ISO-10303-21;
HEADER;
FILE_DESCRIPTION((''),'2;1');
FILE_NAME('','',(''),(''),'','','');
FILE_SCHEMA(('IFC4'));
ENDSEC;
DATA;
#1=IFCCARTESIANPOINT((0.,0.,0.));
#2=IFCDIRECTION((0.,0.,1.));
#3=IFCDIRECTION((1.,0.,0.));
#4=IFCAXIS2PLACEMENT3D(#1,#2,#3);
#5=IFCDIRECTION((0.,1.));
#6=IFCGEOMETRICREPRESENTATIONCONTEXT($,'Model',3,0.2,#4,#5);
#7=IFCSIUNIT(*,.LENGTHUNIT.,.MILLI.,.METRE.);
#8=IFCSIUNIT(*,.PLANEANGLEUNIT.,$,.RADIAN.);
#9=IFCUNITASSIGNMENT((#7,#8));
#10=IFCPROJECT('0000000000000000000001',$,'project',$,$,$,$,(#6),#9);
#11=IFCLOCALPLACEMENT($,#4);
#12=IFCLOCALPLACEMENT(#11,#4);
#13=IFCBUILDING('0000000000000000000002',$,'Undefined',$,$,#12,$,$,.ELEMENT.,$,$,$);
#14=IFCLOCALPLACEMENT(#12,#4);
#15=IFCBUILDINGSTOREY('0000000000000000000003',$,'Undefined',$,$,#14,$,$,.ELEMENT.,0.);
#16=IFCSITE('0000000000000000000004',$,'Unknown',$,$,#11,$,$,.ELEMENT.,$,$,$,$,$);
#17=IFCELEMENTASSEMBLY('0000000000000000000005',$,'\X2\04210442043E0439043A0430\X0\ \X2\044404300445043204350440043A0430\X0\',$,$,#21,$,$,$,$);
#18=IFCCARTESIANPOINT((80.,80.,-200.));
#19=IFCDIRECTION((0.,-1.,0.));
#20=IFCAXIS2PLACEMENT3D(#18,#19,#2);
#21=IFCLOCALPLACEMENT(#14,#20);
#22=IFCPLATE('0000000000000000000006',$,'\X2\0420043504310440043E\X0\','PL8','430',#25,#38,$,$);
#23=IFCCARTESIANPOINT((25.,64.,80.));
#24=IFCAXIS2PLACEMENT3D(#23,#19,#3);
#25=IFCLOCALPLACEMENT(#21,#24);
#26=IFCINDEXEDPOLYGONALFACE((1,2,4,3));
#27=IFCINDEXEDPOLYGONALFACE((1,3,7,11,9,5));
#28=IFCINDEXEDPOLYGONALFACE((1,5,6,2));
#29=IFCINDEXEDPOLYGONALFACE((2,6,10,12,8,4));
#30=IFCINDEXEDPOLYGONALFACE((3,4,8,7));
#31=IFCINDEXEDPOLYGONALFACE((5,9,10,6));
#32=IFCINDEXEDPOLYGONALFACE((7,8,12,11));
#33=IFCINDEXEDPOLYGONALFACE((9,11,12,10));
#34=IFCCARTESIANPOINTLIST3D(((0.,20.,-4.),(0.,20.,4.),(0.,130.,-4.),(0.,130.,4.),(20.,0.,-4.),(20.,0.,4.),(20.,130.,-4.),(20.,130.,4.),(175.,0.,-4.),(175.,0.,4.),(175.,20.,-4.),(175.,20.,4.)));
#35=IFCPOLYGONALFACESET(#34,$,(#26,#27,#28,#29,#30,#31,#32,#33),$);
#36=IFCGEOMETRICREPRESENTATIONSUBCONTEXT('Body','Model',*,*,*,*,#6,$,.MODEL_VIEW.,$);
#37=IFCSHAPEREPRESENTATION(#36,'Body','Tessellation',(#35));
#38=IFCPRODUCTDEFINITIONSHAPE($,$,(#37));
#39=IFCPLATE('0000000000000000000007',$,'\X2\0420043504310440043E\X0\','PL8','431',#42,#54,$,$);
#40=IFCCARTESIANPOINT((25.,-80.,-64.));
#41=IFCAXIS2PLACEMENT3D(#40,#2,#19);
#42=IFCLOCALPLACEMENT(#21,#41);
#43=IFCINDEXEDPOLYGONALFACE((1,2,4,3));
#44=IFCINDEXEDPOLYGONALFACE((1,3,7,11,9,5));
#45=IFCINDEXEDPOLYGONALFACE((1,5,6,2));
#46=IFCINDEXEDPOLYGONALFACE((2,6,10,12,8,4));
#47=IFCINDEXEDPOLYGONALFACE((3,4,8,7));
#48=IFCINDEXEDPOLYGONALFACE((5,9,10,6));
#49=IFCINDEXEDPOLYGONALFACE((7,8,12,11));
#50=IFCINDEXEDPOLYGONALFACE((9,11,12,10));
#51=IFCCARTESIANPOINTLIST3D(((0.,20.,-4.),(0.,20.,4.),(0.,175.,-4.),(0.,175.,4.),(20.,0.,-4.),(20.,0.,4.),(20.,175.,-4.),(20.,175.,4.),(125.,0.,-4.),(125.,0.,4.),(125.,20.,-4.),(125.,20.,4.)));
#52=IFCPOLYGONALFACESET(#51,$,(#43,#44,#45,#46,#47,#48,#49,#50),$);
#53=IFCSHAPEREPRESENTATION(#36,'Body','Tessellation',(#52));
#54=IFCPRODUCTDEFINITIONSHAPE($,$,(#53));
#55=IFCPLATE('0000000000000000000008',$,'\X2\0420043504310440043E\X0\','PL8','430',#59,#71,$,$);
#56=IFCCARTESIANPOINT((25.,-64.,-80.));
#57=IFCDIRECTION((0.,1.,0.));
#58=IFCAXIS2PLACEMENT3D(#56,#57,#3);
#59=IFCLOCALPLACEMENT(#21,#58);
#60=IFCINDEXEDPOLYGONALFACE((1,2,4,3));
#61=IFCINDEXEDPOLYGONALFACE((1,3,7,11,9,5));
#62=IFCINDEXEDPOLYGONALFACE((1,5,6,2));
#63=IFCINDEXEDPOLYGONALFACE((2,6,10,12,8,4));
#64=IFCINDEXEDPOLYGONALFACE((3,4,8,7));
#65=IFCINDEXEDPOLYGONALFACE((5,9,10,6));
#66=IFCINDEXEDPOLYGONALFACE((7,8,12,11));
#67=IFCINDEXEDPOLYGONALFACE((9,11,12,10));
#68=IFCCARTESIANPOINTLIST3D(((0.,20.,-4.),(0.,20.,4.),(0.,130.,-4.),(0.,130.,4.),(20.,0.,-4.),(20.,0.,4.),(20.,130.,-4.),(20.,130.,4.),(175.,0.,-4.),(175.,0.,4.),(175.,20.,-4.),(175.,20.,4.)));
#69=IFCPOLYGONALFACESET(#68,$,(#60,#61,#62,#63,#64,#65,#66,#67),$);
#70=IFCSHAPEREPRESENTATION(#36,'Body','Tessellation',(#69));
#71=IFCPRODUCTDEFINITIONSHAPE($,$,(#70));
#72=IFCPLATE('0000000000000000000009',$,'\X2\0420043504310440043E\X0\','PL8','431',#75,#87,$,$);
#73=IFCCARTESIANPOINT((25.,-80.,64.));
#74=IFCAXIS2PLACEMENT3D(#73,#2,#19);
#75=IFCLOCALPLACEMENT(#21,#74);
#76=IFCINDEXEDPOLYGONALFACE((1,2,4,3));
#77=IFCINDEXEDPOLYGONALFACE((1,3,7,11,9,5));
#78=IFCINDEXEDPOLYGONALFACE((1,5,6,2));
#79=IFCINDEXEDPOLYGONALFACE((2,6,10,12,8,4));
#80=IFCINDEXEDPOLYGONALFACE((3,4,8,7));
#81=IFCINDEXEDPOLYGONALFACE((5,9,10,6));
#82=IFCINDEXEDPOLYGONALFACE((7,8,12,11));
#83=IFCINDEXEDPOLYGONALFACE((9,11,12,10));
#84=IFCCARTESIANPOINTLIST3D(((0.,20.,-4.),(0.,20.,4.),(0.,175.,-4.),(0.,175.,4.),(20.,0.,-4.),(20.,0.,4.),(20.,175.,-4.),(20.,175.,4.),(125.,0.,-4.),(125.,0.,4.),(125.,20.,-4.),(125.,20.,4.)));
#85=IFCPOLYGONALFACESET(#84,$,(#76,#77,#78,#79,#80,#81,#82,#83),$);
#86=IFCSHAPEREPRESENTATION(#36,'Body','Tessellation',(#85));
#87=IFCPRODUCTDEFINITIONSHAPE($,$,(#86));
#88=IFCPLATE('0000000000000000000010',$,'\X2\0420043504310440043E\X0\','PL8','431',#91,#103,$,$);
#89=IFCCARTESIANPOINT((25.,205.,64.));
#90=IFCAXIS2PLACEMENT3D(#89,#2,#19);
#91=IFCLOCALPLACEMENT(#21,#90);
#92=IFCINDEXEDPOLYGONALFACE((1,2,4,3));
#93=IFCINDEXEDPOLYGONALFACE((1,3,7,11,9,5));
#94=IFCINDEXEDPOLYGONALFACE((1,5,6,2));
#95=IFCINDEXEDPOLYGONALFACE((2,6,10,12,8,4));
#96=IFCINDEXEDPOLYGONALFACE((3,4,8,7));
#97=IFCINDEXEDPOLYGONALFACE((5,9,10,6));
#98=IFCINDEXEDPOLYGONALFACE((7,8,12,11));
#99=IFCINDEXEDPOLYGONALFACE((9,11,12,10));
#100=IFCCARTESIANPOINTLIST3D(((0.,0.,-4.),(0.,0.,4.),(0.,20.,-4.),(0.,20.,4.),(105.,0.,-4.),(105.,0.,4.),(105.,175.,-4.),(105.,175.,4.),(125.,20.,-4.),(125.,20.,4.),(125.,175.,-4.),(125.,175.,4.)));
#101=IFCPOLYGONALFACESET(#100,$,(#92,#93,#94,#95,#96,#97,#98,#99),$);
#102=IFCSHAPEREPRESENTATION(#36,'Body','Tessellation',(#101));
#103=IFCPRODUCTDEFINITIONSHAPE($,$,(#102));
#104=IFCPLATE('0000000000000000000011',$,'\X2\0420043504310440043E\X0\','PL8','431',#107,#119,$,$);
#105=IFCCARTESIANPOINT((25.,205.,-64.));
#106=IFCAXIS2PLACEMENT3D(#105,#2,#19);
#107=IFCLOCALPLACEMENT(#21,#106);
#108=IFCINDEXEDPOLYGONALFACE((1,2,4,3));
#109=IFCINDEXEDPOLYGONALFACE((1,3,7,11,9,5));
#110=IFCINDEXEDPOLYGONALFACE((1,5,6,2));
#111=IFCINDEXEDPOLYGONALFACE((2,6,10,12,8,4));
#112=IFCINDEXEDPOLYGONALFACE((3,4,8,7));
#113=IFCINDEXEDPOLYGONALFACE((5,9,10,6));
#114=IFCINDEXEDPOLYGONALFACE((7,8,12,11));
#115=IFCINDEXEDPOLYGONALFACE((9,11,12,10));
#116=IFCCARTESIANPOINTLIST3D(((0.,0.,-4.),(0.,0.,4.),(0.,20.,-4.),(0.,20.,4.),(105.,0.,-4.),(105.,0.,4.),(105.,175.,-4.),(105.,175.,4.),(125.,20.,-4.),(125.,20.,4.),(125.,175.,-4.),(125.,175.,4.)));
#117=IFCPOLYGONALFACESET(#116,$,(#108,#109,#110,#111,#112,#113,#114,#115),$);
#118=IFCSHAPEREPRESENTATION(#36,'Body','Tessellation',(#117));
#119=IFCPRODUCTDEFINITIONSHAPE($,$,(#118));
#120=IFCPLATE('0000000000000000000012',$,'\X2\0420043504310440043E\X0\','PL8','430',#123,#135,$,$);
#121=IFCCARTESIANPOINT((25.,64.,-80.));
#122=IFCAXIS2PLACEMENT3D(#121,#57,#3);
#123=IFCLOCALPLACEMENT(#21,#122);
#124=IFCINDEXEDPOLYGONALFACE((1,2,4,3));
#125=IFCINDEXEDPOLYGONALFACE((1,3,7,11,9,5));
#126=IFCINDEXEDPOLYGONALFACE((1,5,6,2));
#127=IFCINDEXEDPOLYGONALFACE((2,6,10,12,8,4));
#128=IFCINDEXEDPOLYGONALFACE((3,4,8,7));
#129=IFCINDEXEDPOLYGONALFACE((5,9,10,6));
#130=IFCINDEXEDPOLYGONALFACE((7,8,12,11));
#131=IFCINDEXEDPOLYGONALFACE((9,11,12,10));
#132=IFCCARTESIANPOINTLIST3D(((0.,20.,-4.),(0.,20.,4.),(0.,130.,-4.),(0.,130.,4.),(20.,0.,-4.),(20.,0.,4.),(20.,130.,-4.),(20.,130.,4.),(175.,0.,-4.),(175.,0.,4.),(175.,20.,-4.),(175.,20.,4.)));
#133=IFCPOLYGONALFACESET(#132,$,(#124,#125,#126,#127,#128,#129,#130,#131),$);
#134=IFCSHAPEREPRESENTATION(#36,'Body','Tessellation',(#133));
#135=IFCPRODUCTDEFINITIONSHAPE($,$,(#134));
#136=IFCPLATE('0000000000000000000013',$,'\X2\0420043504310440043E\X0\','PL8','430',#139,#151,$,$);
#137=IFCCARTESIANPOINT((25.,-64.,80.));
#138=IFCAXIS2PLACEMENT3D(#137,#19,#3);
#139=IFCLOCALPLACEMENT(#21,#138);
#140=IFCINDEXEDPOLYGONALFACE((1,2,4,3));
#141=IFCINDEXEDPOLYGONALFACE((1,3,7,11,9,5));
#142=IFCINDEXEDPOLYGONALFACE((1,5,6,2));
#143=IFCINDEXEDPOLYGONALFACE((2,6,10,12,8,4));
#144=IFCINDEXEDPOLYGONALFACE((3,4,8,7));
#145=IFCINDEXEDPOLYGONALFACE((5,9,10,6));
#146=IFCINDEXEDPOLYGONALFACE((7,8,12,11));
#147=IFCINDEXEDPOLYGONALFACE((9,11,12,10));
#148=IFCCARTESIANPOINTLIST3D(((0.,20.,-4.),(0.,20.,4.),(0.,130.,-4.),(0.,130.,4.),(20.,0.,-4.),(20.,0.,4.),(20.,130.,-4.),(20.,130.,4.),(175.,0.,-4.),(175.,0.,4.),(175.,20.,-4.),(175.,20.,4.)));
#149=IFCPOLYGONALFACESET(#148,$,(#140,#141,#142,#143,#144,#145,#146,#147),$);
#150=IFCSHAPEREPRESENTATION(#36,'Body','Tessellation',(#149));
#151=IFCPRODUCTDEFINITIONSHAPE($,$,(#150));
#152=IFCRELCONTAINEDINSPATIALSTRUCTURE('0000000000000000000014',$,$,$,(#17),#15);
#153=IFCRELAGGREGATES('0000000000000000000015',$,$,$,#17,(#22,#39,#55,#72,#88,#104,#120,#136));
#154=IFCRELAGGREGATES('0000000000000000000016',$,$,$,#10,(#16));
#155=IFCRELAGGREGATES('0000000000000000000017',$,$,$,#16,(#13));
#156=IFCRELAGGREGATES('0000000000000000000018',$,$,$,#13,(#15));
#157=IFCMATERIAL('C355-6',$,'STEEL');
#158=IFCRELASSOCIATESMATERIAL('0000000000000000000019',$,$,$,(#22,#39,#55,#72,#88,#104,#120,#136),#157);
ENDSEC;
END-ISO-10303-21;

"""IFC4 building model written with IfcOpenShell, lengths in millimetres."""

from ifc_helpers import new_model, si_unit, direction, frame, origin_with_axes, place, context, subcontext, project, spatial, line, indexed_curve, outline, extrude, material, element, aggregate, save


model = new_model("IFC4")

# Units and contexts
model_context = context("Model", 3, precision=0.2, world=origin_with_axes(), true_north=direction((0.0, 1.0)))
body_context = subcontext(model_context, "Body", "Model", "MODEL_VIEW")
ifc_project = project(units=[si_unit("LENGTHUNIT", "METRE", prefix="MILLI"), si_unit("PLANEANGLEUNIT", "RADIAN")], contexts=[model_context])

# Site, building, storey
site_placement = place(None, origin_with_axes())
site = spatial("IfcSite", under=ifc_project, at=site_placement, Name="Unknown", CompositionType="ELEMENT")
building_placement = place(site_placement, origin_with_axes())
building = spatial("IfcBuilding", under=site, at=building_placement, Name="Undefined", CompositionType="ELEMENT")
storey_placement = place(building_placement, origin_with_axes())
storey = spatial("IfcBuildingStorey", under=building, at=storey_placement, Name="Undefined", CompositionType="ELEMENT", Elevation=0.0)

# Element assembly
assembly_1_placement = place(storey_placement, frame((80.0, 80.0, -200.0), z_axis=(0.0, -1.0, 0.0), x_axis=(0.0, 0.0, 1.0)))
assembly_1 = element("IfcElementAssembly", 1, at=assembly_1_placement, inside=storey, Name="Стойка фахверка")
ifc_material_1 = material(Name="C355-6", Category="STEEL")

# Plates
plate_1_placement = place(assembly_1_placement, frame((25.0, 64.0, 80.0), z_axis=(0.0, -1.0, 0.0), x_axis=(1.0, 0.0, 0.0)))
plate_1 = element("IfcPlate", 2, at=plate_1_placement, material=ifc_material_1, Name="Ребро", Description="PL8", ObjectType="430", context=body_context, shape_type="SolidModel", body=[
    extrude(outline(indexed_curve([(0.0, 20.0), (20.0, 0.0), (175.0, 0.0), (175.0, 20.0), (20.0, 130.0), (0.0, 130.0)], segments=[line(1, 2, 3, 4, 5, 6, 1)])), frame((0.0, 0.0, 4.0), z_axis=(0.0, 0.0, 1.0), x_axis=(1.0, 0.0, 0.0)), (0.0, 0.0, -1.0), 8.0),
])
plate_2_placement = place(assembly_1_placement, frame((25.0, -80.0, -64.0), z_axis=(0.0, 0.0, 1.0), x_axis=(0.0, -1.0, 0.0)))
plate_2 = element("IfcPlate", 3, at=plate_2_placement, material=ifc_material_1, Name="Ребро", Description="PL8", ObjectType="431", context=body_context, shape_type="SolidModel", body=[
    extrude(outline(indexed_curve([(0.0, 20.0), (20.0, 0.0), (125.0, 0.0), (125.0, 20.0), (20.0, 175.0), (0.0, 175.0)], segments=[line(1, 2, 3, 4, 5, 6, 1)])), frame((0.0, 0.0, 4.0), z_axis=(0.0, 0.0, 1.0), x_axis=(1.0, 0.0, 0.0)), (0.0, 0.0, -1.0), 8.0),
])
plate_3_placement = place(assembly_1_placement, frame((25.0, -64.0, -80.0), z_axis=(0.0, 1.0, 0.0), x_axis=(1.0, 0.0, 0.0)))
plate_3 = element("IfcPlate", 4, at=plate_3_placement, material=ifc_material_1, Name="Ребро", Description="PL8", ObjectType="430", context=body_context, shape_type="SolidModel", body=[
    extrude(outline(indexed_curve([(0.0, 20.0), (20.0, 0.0), (175.0, 0.0), (175.0, 20.0), (20.0, 130.0), (0.0, 130.0)], segments=[line(1, 2, 3, 4, 5, 6, 1)])), frame((0.0, 0.0, 4.0), z_axis=(0.0, 0.0, 1.0), x_axis=(1.0, 0.0, 0.0)), (0.0, 0.0, -1.0), 8.0),
])
plate_4_placement = place(assembly_1_placement, frame((25.0, -80.0, 64.0), z_axis=(0.0, 0.0, 1.0), x_axis=(0.0, -1.0, 0.0)))
plate_4 = element("IfcPlate", 5, at=plate_4_placement, material=ifc_material_1, Name="Ребро", Description="PL8", ObjectType="431", context=body_context, shape_type="SolidModel", body=[
    extrude(outline(indexed_curve([(0.0, 20.0), (20.0, 0.0), (125.0, 0.0), (125.0, 20.0), (20.0, 175.0), (0.0, 175.0)], segments=[line(1, 2, 3, 4, 5, 6, 1)])), frame((0.0, 0.0, 4.0), z_axis=(0.0, 0.0, 1.0), x_axis=(1.0, 0.0, 0.0)), (0.0, 0.0, -1.0), 8.0),
])
plate_5_placement = place(assembly_1_placement, frame((25.0, 205.0, 64.0), z_axis=(0.0, 0.0, 1.0), x_axis=(0.0, -1.0, 0.0)))
plate_5 = element("IfcPlate", 6, at=plate_5_placement, material=ifc_material_1, Name="Ребро", Description="PL8", ObjectType="431", context=body_context, shape_type="SolidModel", body=[
    extrude(outline(indexed_curve([(0.0, 0.0), (105.0, 0.0), (125.0, 20.0), (125.0, 175.0), (105.0, 175.0), (0.0, 20.0)], segments=[line(1, 2, 3, 4, 5, 6, 1)])), frame((0.0, 0.0, 4.0), z_axis=(0.0, 0.0, 1.0), x_axis=(1.0, 0.0, 0.0)), (0.0, 0.0, -1.0), 8.0),
])
plate_6_placement = place(assembly_1_placement, frame((25.0, 205.0, -64.0), z_axis=(0.0, 0.0, 1.0), x_axis=(0.0, -1.0, 0.0)))
plate_6 = element("IfcPlate", 7, at=plate_6_placement, material=ifc_material_1, Name="Ребро", Description="PL8", ObjectType="431", context=body_context, shape_type="SolidModel", body=[
    extrude(outline(indexed_curve([(0.0, 0.0), (105.0, 0.0), (125.0, 20.0), (125.0, 175.0), (105.0, 175.0), (0.0, 20.0)], segments=[line(1, 2, 3, 4, 5, 6, 1)])), frame((0.0, 0.0, 4.0), z_axis=(0.0, 0.0, 1.0), x_axis=(1.0, 0.0, 0.0)), (0.0, 0.0, -1.0), 8.0),
])
plate_7_placement = place(assembly_1_placement, frame((25.0, 64.0, -80.0), z_axis=(0.0, 1.0, 0.0), x_axis=(1.0, 0.0, 0.0)))
plate_7 = element("IfcPlate", 8, at=plate_7_placement, material=ifc_material_1, Name="Ребро", Description="PL8", ObjectType="430", context=body_context, shape_type="SolidModel", body=[
    extrude(outline(indexed_curve([(0.0, 20.0), (20.0, 0.0), (175.0, 0.0), (175.0, 20.0), (20.0, 130.0), (0.0, 130.0)], segments=[line(1, 2, 3, 4, 5, 6, 1)])), frame((0.0, 0.0, 4.0), z_axis=(0.0, 0.0, 1.0), x_axis=(1.0, 0.0, 0.0)), (0.0, 0.0, -1.0), 8.0),
])
plate_8_placement = place(assembly_1_placement, frame((25.0, -64.0, 80.0), z_axis=(0.0, -1.0, 0.0), x_axis=(1.0, 0.0, 0.0)))
plate_8 = element("IfcPlate", 9, at=plate_8_placement, material=ifc_material_1, Name="Ребро", Description="PL8", ObjectType="430", context=body_context, shape_type="SolidModel", body=[
    extrude(outline(indexed_curve([(0.0, 20.0), (20.0, 0.0), (175.0, 0.0), (175.0, 20.0), (20.0, 130.0), (0.0, 130.0)], segments=[line(1, 2, 3, 4, 5, 6, 1)])), frame((0.0, 0.0, 4.0), z_axis=(0.0, 0.0, 1.0), x_axis=(1.0, 0.0, 0.0)), (0.0, 0.0, -1.0), 8.0),
])

aggregate(assembly_1, [plate_1, plate_2, plate_3, plate_4, plate_5, plate_6, plate_7, plate_8])

save(model, "model.ifc")
